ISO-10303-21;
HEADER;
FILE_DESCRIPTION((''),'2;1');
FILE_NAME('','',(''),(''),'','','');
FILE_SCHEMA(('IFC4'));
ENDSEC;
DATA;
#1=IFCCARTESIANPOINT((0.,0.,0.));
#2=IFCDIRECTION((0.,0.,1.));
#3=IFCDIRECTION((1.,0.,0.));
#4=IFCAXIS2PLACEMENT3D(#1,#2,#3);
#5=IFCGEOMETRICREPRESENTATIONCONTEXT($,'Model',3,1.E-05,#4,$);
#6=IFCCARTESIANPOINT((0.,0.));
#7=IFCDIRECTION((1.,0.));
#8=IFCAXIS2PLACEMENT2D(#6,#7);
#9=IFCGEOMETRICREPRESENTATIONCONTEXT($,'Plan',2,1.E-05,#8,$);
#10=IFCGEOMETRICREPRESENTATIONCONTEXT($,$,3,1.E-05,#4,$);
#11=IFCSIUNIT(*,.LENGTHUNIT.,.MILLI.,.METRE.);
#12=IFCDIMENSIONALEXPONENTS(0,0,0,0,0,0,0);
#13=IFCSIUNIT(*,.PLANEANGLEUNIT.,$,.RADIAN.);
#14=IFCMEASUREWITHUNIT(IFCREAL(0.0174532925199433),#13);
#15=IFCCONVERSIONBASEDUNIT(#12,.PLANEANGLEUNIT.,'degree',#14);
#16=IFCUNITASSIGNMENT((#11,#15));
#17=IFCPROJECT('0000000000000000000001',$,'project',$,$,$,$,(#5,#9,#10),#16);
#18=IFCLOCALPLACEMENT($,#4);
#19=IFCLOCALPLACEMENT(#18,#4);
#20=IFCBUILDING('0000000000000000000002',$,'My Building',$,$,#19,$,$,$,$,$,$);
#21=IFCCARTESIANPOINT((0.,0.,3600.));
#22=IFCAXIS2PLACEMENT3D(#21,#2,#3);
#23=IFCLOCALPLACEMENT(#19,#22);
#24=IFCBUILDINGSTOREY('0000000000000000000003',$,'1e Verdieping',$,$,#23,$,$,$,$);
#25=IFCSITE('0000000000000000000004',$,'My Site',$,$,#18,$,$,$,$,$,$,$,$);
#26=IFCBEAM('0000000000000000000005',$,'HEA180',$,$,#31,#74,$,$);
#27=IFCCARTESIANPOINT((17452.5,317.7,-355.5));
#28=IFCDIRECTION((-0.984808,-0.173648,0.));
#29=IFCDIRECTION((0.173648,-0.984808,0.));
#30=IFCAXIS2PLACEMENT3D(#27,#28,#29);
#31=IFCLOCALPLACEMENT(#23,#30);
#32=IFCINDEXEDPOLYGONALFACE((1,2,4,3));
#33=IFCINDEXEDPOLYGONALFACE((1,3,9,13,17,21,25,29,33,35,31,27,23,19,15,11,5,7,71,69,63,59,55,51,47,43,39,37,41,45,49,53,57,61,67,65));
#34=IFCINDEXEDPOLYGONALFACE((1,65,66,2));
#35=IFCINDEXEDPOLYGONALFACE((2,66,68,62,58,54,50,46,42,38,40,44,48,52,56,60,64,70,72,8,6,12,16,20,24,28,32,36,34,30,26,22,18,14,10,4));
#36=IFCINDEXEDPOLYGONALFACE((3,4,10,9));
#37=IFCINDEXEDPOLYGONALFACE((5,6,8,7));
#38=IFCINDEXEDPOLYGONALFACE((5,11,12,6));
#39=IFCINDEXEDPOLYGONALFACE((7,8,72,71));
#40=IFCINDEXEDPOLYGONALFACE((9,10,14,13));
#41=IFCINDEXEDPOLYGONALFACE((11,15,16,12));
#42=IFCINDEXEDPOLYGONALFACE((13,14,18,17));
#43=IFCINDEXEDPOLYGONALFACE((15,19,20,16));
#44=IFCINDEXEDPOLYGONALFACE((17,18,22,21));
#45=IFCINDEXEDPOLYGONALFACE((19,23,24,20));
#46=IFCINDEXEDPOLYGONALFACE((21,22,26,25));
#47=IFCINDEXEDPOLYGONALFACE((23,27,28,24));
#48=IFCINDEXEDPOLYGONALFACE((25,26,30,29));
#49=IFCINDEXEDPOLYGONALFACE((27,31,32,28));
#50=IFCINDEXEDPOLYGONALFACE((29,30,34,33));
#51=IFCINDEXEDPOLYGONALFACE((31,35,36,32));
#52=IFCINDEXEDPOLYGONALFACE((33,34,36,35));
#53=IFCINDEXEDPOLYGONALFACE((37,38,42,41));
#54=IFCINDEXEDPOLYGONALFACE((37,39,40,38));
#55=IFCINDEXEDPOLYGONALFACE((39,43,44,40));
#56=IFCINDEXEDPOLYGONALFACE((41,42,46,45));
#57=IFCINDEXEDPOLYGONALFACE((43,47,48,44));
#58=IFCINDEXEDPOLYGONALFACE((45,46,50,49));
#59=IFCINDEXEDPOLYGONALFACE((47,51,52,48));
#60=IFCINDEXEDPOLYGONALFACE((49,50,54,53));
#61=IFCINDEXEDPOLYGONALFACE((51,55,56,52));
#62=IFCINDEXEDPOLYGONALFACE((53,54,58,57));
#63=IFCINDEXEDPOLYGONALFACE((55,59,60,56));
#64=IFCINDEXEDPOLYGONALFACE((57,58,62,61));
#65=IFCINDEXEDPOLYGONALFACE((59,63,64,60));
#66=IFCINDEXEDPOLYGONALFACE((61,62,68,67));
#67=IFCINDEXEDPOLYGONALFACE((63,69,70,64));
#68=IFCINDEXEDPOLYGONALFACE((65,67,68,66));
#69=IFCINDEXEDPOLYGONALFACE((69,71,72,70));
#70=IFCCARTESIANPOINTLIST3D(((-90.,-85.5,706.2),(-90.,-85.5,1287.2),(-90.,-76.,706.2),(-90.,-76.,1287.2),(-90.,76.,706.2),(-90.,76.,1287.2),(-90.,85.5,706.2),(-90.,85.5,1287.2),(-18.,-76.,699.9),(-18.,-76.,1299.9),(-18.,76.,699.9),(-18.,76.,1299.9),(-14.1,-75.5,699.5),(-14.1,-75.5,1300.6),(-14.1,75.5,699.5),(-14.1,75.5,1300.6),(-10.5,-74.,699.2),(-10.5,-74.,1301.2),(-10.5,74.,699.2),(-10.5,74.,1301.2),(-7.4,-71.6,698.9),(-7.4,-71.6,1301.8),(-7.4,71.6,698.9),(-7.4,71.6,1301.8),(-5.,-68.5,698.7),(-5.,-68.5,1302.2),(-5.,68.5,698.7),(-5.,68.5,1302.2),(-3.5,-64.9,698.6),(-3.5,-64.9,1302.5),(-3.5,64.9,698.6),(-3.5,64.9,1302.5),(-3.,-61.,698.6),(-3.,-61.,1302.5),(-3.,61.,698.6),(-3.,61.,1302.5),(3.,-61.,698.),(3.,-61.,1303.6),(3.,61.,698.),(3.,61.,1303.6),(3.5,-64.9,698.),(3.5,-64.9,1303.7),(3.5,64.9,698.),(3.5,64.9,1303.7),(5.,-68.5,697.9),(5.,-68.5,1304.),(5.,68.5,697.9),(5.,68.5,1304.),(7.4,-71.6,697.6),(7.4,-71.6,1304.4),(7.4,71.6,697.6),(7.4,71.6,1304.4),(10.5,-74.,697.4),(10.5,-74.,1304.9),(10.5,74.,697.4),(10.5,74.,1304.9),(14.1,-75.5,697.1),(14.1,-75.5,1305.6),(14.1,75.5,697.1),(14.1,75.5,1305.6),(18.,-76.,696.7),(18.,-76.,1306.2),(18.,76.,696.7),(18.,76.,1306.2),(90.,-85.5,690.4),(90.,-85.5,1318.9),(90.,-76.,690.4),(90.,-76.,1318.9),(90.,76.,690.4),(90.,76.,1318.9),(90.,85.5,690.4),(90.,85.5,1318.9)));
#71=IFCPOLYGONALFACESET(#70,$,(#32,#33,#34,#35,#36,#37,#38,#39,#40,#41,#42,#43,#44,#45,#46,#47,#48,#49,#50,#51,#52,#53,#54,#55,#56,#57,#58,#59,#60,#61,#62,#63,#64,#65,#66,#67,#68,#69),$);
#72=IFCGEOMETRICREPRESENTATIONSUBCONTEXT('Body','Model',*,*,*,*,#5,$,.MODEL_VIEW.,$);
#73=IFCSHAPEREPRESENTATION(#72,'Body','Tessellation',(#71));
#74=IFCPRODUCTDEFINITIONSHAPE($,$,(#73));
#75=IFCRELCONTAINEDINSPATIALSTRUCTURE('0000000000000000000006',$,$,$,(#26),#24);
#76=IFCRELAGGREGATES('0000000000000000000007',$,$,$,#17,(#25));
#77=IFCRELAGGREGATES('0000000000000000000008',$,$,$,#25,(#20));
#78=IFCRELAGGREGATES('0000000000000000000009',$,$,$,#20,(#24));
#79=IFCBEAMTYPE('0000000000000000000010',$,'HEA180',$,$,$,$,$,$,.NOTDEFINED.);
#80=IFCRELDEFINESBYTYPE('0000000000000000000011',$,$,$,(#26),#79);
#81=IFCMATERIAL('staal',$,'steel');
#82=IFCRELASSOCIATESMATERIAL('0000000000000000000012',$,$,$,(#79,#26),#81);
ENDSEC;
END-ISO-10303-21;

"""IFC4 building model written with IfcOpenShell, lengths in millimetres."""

from ifc_helpers import new_model, entity, si_unit, converted_unit, frame, origin_with_axes, origin_2d_with_axis, place, context, subcontext, project, spatial, i_section, extrude, clip, halfspace, material, material_profile, profile_set, profile_usage, type_object, element, save


model = new_model("IFC4")

# Units and contexts
model_context = context("Model", 3, precision=1e-05, world=origin_with_axes())
plan_context = context("Plan", 2, precision=1e-05, world=origin_2d_with_axis())
context_of_model = context(None, 3, precision=1e-05, world=origin_with_axes())
body_context = subcontext(model_context, "Body", "Model", "MODEL_VIEW")
ifc_project = project(units=[si_unit("LENGTHUNIT", "METRE", prefix="MILLI"), converted_unit("PLANEANGLEUNIT", "degree", entity("IfcReal", 0.0174532925199433), si_unit("PLANEANGLEUNIT", "RADIAN"), dimensions=[0, 0, 0, 0, 0, 0, 0])], contexts=[model_context, plan_context, context_of_model])

# Site, building, storey
site_placement = place(None, origin_with_axes())
site = spatial("IfcSite", under=ifc_project, at=site_placement, Name="My Site")
building_placement = place(site_placement, origin_with_axes())
building = spatial("IfcBuilding", under=site, at=building_placement, Name="My Building")
storey_placement = place(building_placement, frame((0.0, 0.0, 3600.0), z_axis=(0.0, 0.0, 1.0), x_axis=(1.0, 0.0, 0.0)))
storey = spatial("IfcBuildingStorey", under=building, at=storey_placement, Name="1e Verdieping")

# Shared definitions
ifc_material = material(Name="staal", Category="steel")

# Beam
ifc_material_profile_1 = material_profile(ifc_material, i_section(OverallWidth=180.0, OverallDepth=171.0, WebThickness=6.0, FlangeThickness=9.5, FilletRadius=15.0))
ifc_profile_set_1 = profile_set([ifc_material_profile_1], Name="HEA180")
beam_type_1 = type_object("IfcBeamType", Name="HEA180", PredefinedType="NOTDEFINED", material=ifc_profile_set_1)
ifc_profile_usage_1 = profile_usage(ifc_profile_set_1)
beam_1_placement = place(storey_placement, frame((17452.5, 317.7, -355.5), z_axis=(-0.984808, -0.173648, 0.0), x_axis=(0.173648, -0.984808, 0.0)))
element("IfcBeam", 1, at=beam_1_placement, inside=storey, type_object=beam_type_1, material=ifc_profile_usage_1, Name="HEA180", context=body_context, shape_type="Clipping", body=[
    clip(clip(extrude(i_section(OverallWidth=180.0, OverallDepth=171.0, WebThickness=6.0, FlangeThickness=9.5, FilletRadius=15.0), origin_with_axes(), (0.0, 0.0, 1.0), 1746.2), halfspace(frame((90.0, -3320.5, 1318.9), z_axis=(-0.173637, 0.0, 0.98481), x_axis=(0.000001, 1.0, 0.0)), False)), halfspace(frame((90.0, -3320.5, 690.4), z_axis=(-0.087161, 0.0, -0.996194), x_axis=(0.000001, 1.0, 0.0)), False)),
])

save(model, "model.ifc")
